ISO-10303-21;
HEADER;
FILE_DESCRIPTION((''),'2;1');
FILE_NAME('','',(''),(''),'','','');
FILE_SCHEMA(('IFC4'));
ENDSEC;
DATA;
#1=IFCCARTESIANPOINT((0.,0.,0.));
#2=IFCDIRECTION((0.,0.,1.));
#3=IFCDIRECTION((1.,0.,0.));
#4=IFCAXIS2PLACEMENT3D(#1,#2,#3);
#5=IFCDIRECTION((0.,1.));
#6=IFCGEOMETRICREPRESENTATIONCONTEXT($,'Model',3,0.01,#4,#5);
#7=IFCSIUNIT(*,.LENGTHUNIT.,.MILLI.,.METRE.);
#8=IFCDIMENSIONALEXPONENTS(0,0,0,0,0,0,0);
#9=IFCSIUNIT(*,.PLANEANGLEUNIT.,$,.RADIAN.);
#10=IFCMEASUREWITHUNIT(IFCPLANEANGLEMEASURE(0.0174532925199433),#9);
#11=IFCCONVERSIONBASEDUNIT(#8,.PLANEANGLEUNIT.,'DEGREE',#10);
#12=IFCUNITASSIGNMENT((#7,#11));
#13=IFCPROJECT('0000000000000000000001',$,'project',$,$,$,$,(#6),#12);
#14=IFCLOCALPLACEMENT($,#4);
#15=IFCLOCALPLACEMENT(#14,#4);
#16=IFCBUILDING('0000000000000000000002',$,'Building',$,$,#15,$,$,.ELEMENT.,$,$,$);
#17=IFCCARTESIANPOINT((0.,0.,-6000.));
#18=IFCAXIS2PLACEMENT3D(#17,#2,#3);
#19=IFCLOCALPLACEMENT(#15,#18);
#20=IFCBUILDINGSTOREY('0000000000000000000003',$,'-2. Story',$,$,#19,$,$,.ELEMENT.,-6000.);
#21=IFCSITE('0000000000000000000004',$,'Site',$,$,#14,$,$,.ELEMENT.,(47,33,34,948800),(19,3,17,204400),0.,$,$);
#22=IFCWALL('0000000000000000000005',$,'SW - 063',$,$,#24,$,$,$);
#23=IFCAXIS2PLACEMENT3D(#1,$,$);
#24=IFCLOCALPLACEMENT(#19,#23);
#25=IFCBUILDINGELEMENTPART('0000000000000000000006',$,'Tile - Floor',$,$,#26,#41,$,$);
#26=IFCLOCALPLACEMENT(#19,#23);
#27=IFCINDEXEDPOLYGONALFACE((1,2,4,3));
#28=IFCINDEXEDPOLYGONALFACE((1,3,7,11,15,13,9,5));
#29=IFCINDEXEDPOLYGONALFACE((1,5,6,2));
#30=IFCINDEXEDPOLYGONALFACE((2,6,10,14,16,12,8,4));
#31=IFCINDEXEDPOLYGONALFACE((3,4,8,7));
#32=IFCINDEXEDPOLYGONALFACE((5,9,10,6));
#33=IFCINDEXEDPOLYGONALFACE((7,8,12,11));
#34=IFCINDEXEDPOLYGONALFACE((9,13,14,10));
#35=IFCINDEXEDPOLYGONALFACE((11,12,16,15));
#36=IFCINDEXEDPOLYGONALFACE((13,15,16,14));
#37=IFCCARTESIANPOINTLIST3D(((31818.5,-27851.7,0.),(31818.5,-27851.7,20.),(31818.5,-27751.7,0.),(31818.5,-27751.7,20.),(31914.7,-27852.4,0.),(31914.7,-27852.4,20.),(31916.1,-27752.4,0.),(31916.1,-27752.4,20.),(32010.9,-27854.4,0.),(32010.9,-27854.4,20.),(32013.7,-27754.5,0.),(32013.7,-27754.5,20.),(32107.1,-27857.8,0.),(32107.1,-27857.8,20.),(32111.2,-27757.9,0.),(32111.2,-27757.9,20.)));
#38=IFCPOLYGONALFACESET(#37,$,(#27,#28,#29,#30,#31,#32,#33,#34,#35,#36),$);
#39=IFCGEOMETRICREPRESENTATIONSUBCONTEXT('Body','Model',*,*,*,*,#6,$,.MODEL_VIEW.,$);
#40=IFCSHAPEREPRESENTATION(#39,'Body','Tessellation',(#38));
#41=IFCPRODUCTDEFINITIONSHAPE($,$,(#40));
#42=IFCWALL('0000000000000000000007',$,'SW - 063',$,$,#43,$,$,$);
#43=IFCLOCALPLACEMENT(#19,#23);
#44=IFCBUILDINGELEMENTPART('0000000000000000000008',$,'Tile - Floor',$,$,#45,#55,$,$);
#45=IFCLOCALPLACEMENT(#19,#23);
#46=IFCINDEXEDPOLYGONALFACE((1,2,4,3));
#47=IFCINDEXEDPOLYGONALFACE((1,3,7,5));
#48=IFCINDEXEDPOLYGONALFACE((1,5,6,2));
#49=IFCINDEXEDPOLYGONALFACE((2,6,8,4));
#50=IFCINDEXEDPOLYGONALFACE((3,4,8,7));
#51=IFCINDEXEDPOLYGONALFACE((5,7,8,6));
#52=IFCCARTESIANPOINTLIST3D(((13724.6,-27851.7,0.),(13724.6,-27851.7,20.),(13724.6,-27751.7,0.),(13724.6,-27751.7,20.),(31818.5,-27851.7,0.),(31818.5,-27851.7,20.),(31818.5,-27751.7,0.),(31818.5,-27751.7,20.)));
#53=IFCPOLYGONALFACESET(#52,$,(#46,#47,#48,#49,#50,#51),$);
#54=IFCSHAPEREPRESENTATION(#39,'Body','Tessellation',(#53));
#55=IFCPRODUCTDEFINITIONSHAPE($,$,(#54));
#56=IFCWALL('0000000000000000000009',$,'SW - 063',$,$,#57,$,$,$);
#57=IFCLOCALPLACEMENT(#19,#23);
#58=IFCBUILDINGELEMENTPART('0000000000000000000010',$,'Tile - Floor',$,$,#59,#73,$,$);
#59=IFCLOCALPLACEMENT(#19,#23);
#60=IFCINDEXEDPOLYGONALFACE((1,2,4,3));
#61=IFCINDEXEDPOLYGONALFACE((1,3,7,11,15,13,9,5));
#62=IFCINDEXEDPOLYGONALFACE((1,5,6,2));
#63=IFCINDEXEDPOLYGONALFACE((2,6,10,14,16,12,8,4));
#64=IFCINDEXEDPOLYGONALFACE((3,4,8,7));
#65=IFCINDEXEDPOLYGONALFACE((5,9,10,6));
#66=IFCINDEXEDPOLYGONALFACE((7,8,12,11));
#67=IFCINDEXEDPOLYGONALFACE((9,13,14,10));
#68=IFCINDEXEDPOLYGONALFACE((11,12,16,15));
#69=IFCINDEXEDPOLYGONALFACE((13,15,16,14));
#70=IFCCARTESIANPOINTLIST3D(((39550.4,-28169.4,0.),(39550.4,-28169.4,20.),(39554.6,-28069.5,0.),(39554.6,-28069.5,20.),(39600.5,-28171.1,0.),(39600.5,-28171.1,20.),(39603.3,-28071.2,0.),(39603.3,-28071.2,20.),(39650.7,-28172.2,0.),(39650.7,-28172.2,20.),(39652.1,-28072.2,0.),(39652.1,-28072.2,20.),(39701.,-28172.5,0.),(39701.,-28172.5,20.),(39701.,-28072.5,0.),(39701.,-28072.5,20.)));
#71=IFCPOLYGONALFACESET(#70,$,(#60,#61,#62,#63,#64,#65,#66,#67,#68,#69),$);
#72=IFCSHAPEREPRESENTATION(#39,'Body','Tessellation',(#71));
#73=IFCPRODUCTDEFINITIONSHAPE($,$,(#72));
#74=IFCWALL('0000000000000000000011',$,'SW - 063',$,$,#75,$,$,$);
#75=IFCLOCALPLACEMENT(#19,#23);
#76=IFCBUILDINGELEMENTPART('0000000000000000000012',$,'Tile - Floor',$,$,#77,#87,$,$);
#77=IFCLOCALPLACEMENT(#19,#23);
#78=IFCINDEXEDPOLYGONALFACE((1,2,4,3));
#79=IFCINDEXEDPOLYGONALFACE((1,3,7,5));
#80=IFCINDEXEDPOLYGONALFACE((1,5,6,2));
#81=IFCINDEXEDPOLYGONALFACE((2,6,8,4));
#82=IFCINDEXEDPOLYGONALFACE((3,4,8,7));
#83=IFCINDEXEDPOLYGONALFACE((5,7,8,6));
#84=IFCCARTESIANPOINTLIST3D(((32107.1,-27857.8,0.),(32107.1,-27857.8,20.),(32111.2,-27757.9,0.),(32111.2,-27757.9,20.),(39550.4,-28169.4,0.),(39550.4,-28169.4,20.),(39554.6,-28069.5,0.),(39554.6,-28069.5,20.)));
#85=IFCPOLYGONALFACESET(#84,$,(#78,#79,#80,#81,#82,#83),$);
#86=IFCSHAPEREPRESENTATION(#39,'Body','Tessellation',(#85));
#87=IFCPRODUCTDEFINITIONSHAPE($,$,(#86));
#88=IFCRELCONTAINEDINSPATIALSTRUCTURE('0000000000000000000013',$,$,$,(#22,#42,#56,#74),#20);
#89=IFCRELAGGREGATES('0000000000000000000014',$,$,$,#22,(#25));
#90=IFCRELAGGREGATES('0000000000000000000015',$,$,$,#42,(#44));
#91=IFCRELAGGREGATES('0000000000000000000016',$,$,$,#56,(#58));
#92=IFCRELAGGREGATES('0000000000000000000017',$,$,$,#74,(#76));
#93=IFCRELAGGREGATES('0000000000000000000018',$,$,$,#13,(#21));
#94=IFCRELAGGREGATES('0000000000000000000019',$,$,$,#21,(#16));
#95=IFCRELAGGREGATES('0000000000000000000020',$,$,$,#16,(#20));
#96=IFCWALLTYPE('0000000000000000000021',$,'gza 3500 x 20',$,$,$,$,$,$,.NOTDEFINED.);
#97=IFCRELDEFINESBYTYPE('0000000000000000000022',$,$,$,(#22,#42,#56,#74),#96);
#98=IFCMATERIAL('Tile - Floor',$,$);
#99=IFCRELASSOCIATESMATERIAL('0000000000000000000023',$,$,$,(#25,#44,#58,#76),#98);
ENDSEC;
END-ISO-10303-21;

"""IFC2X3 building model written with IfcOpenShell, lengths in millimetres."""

from ifc_helpers import new_model, entity, si_unit, converted_unit, direction, frame, origin_with_axes, place, context, subcontext, project, spatial, polyline, outline, extrude, material, type_object, element, aggregate, save


model = new_model("IFC2X3")

# Units and contexts
model_context = context("Model", 3, precision=0.01, world=origin_with_axes(), true_north=direction((0.0, 1.0)))
body_context = subcontext(model_context, "Body", "Model", "MODEL_VIEW")
ifc_project = project(units=[si_unit("LENGTHUNIT", "METRE", prefix="MILLI"), converted_unit("PLANEANGLEUNIT", "DEGREE", entity("IfcPlaneAngleMeasure", 0.0174532925199433), si_unit("PLANEANGLEUNIT", "RADIAN"), dimensions=[0, 0, 0, 0, 0, 0, 0])], contexts=[model_context])

# Site, building, storey
site_placement = place(None, origin_with_axes())
site = spatial("IfcSite", under=ifc_project, at=site_placement, Name="Site", CompositionType="ELEMENT", RefLatitude=(47, 33, 34, 948800), RefLongitude=(19, 3, 17, 204400), RefElevation=0.0)
building_placement = place(site_placement, origin_with_axes())
building = spatial("IfcBuilding", under=site, at=building_placement, Name="Building", CompositionType="ELEMENT")
storey_placement = place(building_placement, frame((0.0, 0.0, -6000.0), z_axis=(0.0, 0.0, 1.0), x_axis=(1.0, 0.0, 0.0)))
storey = spatial("IfcBuildingStorey", under=building, at=storey_placement, Name="-2. Story", CompositionType="ELEMENT", Elevation=-6000.0)

# Walls, building element parts
wall_type_1 = type_object("IfcWallType", Name="gza 3500 x 20", PredefinedType="NOTDEFINED")
ifc_material_1 = material(Name="Tile - Floor")
wall_1_placement = place(storey_placement, frame((32111.2, -27757.9, 0.0), z_axis=(0.0, 0.0, 1.0), x_axis=(-0.999125, 0.041827, 0.0)))
wall_1 = element("IfcWall", 1, at=wall_1_placement, inside=storey, type_object=wall_type_1, Name="SW - 063")
building_element_part_1_placement = place(wall_1_placement, origin_with_axes())
cartesian_point_1 = entity("IfcCartesianPoint", [100.0, 0.0])
building_element_part_1 = element("IfcBuildingElementPart", 2, at=building_element_part_1_placement, material=ifc_material_1, Name="Tile - Floor", context=body_context, shape_type="SweptSolid", body=[
    entity("IfcRevolvedAreaSolid", entity("IfcArbitraryClosedProfileDef", "AREA", None, entity("IfcPolyline", [cartesian_point_1, entity("IfcCartesianPoint", [100.0, 20.0]), entity("IfcCartesianPoint", [0.0, 20.0]), entity("IfcCartesianPoint", [0.0, 0.0]), cartesian_point_1])), entity("IfcAxis2Placement3D", entity("IfcCartesianPoint", [0.0, 0.0, 0.0]), entity("IfcDirection", [1.0, 0.0, 0.0]), entity("IfcDirection", [0.0, 1.0, 0.0])), entity("IfcAxis1Placement", entity("IfcCartesianPoint", [7000.0, 0.0, 0.0]), entity("IfcDirection", [0.0, 1.0, 0.0])), 2.397219),
])
aggregate(wall_1, [building_element_part_1])
wall_2_placement = place(storey_placement, frame((31818.5, -27751.7, 0.0), z_axis=(0.0, 0.0, 1.0), x_axis=(-1.0, 0.0, 0.0)))
wall_2 = element("IfcWall", 3, at=wall_2_placement, inside=storey, type_object=wall_type_1, Name="SW - 063")
building_element_part_2_placement = place(wall_2_placement, origin_with_axes())
building_element_part_2 = element("IfcBuildingElementPart", 4, at=building_element_part_2_placement, material=ifc_material_1, Name="Tile - Floor", context=body_context, shape_type="SweptSolid", body=[
    extrude(outline(polyline([(100.0, 0.0), (100.0, 20.0), (0.0, 20.0), (0.0, 0.0), (100.0, 0.0)])), frame((0.0, 0.0, 0.0), z_axis=(1.0, 0.0, 0.0), x_axis=(0.0, 1.0, 0.0)), (0.0, 0.0, 1.0), 18093.9),
])
aggregate(wall_2, [building_element_part_2])
wall_3_placement = place(storey_placement, frame((39554.6, -28069.5, 0.0), z_axis=(0.0, 0.0, 1.0), x_axis=(0.999125, -0.041827, 0.0)))
wall_3 = element("IfcWall", 5, at=wall_3_placement, inside=storey, type_object=wall_type_1, Name="SW - 063")
building_element_part_3_placement = place(wall_3_placement, origin_with_axes())
cartesian_point_2 = entity("IfcCartesianPoint", [100.0, 0.0])
building_element_part_3 = element("IfcBuildingElementPart", 6, at=building_element_part_3_placement, material=ifc_material_1, Name="Tile - Floor", context=body_context, shape_type="SweptSolid", body=[
    entity("IfcRevolvedAreaSolid", entity("IfcArbitraryClosedProfileDef", "AREA", None, entity("IfcPolyline", [cartesian_point_2, entity("IfcCartesianPoint", [100.0, 20.0]), entity("IfcCartesianPoint", [0.0, 20.0]), entity("IfcCartesianPoint", [0.0, 0.0]), cartesian_point_2])), entity("IfcAxis2Placement3D", entity("IfcCartesianPoint", [0.0, 0.0, 0.0]), entity("IfcDirection", [-1.0, 0.0, 0.0]), entity("IfcDirection", [0.0, -1.0, 0.0])), entity("IfcAxis1Placement", entity("IfcCartesianPoint", [-3500.0, 0.0, 0.0]), entity("IfcDirection", [0.0, 1.0, 0.0])), 2.397219),
])
aggregate(wall_3, [building_element_part_3])
wall_4_placement = place(storey_placement, frame((32111.2, -27757.9, 0.0), z_axis=(0.0, 0.0, 1.0), x_axis=(0.999125, -0.041827, 0.0)))
wall_4 = element("IfcWall", 7, at=wall_4_placement, inside=storey, type_object=wall_type_1, Name="SW - 063")
building_element_part_4_placement = place(wall_4_placement, origin_with_axes())
building_element_part_4 = element("IfcBuildingElementPart", 8, at=building_element_part_4_placement, material=ifc_material_1, Name="Tile - Floor", context=body_context, shape_type="SweptSolid", body=[
    extrude(outline(polyline([(100.0, 0.0), (100.0, 20.0), (0.0, 20.0), (0.0, 0.0), (100.0, 0.0)])), frame((0.0, 0.0, 0.0), z_axis=(-1.0, 0.0, 0.0), x_axis=(0.0, -1.0, 0.0)), (0.0, 0.0, -1.0), 7449.8),
])
aggregate(wall_4, [building_element_part_4])

save(model, "model.ifc")
